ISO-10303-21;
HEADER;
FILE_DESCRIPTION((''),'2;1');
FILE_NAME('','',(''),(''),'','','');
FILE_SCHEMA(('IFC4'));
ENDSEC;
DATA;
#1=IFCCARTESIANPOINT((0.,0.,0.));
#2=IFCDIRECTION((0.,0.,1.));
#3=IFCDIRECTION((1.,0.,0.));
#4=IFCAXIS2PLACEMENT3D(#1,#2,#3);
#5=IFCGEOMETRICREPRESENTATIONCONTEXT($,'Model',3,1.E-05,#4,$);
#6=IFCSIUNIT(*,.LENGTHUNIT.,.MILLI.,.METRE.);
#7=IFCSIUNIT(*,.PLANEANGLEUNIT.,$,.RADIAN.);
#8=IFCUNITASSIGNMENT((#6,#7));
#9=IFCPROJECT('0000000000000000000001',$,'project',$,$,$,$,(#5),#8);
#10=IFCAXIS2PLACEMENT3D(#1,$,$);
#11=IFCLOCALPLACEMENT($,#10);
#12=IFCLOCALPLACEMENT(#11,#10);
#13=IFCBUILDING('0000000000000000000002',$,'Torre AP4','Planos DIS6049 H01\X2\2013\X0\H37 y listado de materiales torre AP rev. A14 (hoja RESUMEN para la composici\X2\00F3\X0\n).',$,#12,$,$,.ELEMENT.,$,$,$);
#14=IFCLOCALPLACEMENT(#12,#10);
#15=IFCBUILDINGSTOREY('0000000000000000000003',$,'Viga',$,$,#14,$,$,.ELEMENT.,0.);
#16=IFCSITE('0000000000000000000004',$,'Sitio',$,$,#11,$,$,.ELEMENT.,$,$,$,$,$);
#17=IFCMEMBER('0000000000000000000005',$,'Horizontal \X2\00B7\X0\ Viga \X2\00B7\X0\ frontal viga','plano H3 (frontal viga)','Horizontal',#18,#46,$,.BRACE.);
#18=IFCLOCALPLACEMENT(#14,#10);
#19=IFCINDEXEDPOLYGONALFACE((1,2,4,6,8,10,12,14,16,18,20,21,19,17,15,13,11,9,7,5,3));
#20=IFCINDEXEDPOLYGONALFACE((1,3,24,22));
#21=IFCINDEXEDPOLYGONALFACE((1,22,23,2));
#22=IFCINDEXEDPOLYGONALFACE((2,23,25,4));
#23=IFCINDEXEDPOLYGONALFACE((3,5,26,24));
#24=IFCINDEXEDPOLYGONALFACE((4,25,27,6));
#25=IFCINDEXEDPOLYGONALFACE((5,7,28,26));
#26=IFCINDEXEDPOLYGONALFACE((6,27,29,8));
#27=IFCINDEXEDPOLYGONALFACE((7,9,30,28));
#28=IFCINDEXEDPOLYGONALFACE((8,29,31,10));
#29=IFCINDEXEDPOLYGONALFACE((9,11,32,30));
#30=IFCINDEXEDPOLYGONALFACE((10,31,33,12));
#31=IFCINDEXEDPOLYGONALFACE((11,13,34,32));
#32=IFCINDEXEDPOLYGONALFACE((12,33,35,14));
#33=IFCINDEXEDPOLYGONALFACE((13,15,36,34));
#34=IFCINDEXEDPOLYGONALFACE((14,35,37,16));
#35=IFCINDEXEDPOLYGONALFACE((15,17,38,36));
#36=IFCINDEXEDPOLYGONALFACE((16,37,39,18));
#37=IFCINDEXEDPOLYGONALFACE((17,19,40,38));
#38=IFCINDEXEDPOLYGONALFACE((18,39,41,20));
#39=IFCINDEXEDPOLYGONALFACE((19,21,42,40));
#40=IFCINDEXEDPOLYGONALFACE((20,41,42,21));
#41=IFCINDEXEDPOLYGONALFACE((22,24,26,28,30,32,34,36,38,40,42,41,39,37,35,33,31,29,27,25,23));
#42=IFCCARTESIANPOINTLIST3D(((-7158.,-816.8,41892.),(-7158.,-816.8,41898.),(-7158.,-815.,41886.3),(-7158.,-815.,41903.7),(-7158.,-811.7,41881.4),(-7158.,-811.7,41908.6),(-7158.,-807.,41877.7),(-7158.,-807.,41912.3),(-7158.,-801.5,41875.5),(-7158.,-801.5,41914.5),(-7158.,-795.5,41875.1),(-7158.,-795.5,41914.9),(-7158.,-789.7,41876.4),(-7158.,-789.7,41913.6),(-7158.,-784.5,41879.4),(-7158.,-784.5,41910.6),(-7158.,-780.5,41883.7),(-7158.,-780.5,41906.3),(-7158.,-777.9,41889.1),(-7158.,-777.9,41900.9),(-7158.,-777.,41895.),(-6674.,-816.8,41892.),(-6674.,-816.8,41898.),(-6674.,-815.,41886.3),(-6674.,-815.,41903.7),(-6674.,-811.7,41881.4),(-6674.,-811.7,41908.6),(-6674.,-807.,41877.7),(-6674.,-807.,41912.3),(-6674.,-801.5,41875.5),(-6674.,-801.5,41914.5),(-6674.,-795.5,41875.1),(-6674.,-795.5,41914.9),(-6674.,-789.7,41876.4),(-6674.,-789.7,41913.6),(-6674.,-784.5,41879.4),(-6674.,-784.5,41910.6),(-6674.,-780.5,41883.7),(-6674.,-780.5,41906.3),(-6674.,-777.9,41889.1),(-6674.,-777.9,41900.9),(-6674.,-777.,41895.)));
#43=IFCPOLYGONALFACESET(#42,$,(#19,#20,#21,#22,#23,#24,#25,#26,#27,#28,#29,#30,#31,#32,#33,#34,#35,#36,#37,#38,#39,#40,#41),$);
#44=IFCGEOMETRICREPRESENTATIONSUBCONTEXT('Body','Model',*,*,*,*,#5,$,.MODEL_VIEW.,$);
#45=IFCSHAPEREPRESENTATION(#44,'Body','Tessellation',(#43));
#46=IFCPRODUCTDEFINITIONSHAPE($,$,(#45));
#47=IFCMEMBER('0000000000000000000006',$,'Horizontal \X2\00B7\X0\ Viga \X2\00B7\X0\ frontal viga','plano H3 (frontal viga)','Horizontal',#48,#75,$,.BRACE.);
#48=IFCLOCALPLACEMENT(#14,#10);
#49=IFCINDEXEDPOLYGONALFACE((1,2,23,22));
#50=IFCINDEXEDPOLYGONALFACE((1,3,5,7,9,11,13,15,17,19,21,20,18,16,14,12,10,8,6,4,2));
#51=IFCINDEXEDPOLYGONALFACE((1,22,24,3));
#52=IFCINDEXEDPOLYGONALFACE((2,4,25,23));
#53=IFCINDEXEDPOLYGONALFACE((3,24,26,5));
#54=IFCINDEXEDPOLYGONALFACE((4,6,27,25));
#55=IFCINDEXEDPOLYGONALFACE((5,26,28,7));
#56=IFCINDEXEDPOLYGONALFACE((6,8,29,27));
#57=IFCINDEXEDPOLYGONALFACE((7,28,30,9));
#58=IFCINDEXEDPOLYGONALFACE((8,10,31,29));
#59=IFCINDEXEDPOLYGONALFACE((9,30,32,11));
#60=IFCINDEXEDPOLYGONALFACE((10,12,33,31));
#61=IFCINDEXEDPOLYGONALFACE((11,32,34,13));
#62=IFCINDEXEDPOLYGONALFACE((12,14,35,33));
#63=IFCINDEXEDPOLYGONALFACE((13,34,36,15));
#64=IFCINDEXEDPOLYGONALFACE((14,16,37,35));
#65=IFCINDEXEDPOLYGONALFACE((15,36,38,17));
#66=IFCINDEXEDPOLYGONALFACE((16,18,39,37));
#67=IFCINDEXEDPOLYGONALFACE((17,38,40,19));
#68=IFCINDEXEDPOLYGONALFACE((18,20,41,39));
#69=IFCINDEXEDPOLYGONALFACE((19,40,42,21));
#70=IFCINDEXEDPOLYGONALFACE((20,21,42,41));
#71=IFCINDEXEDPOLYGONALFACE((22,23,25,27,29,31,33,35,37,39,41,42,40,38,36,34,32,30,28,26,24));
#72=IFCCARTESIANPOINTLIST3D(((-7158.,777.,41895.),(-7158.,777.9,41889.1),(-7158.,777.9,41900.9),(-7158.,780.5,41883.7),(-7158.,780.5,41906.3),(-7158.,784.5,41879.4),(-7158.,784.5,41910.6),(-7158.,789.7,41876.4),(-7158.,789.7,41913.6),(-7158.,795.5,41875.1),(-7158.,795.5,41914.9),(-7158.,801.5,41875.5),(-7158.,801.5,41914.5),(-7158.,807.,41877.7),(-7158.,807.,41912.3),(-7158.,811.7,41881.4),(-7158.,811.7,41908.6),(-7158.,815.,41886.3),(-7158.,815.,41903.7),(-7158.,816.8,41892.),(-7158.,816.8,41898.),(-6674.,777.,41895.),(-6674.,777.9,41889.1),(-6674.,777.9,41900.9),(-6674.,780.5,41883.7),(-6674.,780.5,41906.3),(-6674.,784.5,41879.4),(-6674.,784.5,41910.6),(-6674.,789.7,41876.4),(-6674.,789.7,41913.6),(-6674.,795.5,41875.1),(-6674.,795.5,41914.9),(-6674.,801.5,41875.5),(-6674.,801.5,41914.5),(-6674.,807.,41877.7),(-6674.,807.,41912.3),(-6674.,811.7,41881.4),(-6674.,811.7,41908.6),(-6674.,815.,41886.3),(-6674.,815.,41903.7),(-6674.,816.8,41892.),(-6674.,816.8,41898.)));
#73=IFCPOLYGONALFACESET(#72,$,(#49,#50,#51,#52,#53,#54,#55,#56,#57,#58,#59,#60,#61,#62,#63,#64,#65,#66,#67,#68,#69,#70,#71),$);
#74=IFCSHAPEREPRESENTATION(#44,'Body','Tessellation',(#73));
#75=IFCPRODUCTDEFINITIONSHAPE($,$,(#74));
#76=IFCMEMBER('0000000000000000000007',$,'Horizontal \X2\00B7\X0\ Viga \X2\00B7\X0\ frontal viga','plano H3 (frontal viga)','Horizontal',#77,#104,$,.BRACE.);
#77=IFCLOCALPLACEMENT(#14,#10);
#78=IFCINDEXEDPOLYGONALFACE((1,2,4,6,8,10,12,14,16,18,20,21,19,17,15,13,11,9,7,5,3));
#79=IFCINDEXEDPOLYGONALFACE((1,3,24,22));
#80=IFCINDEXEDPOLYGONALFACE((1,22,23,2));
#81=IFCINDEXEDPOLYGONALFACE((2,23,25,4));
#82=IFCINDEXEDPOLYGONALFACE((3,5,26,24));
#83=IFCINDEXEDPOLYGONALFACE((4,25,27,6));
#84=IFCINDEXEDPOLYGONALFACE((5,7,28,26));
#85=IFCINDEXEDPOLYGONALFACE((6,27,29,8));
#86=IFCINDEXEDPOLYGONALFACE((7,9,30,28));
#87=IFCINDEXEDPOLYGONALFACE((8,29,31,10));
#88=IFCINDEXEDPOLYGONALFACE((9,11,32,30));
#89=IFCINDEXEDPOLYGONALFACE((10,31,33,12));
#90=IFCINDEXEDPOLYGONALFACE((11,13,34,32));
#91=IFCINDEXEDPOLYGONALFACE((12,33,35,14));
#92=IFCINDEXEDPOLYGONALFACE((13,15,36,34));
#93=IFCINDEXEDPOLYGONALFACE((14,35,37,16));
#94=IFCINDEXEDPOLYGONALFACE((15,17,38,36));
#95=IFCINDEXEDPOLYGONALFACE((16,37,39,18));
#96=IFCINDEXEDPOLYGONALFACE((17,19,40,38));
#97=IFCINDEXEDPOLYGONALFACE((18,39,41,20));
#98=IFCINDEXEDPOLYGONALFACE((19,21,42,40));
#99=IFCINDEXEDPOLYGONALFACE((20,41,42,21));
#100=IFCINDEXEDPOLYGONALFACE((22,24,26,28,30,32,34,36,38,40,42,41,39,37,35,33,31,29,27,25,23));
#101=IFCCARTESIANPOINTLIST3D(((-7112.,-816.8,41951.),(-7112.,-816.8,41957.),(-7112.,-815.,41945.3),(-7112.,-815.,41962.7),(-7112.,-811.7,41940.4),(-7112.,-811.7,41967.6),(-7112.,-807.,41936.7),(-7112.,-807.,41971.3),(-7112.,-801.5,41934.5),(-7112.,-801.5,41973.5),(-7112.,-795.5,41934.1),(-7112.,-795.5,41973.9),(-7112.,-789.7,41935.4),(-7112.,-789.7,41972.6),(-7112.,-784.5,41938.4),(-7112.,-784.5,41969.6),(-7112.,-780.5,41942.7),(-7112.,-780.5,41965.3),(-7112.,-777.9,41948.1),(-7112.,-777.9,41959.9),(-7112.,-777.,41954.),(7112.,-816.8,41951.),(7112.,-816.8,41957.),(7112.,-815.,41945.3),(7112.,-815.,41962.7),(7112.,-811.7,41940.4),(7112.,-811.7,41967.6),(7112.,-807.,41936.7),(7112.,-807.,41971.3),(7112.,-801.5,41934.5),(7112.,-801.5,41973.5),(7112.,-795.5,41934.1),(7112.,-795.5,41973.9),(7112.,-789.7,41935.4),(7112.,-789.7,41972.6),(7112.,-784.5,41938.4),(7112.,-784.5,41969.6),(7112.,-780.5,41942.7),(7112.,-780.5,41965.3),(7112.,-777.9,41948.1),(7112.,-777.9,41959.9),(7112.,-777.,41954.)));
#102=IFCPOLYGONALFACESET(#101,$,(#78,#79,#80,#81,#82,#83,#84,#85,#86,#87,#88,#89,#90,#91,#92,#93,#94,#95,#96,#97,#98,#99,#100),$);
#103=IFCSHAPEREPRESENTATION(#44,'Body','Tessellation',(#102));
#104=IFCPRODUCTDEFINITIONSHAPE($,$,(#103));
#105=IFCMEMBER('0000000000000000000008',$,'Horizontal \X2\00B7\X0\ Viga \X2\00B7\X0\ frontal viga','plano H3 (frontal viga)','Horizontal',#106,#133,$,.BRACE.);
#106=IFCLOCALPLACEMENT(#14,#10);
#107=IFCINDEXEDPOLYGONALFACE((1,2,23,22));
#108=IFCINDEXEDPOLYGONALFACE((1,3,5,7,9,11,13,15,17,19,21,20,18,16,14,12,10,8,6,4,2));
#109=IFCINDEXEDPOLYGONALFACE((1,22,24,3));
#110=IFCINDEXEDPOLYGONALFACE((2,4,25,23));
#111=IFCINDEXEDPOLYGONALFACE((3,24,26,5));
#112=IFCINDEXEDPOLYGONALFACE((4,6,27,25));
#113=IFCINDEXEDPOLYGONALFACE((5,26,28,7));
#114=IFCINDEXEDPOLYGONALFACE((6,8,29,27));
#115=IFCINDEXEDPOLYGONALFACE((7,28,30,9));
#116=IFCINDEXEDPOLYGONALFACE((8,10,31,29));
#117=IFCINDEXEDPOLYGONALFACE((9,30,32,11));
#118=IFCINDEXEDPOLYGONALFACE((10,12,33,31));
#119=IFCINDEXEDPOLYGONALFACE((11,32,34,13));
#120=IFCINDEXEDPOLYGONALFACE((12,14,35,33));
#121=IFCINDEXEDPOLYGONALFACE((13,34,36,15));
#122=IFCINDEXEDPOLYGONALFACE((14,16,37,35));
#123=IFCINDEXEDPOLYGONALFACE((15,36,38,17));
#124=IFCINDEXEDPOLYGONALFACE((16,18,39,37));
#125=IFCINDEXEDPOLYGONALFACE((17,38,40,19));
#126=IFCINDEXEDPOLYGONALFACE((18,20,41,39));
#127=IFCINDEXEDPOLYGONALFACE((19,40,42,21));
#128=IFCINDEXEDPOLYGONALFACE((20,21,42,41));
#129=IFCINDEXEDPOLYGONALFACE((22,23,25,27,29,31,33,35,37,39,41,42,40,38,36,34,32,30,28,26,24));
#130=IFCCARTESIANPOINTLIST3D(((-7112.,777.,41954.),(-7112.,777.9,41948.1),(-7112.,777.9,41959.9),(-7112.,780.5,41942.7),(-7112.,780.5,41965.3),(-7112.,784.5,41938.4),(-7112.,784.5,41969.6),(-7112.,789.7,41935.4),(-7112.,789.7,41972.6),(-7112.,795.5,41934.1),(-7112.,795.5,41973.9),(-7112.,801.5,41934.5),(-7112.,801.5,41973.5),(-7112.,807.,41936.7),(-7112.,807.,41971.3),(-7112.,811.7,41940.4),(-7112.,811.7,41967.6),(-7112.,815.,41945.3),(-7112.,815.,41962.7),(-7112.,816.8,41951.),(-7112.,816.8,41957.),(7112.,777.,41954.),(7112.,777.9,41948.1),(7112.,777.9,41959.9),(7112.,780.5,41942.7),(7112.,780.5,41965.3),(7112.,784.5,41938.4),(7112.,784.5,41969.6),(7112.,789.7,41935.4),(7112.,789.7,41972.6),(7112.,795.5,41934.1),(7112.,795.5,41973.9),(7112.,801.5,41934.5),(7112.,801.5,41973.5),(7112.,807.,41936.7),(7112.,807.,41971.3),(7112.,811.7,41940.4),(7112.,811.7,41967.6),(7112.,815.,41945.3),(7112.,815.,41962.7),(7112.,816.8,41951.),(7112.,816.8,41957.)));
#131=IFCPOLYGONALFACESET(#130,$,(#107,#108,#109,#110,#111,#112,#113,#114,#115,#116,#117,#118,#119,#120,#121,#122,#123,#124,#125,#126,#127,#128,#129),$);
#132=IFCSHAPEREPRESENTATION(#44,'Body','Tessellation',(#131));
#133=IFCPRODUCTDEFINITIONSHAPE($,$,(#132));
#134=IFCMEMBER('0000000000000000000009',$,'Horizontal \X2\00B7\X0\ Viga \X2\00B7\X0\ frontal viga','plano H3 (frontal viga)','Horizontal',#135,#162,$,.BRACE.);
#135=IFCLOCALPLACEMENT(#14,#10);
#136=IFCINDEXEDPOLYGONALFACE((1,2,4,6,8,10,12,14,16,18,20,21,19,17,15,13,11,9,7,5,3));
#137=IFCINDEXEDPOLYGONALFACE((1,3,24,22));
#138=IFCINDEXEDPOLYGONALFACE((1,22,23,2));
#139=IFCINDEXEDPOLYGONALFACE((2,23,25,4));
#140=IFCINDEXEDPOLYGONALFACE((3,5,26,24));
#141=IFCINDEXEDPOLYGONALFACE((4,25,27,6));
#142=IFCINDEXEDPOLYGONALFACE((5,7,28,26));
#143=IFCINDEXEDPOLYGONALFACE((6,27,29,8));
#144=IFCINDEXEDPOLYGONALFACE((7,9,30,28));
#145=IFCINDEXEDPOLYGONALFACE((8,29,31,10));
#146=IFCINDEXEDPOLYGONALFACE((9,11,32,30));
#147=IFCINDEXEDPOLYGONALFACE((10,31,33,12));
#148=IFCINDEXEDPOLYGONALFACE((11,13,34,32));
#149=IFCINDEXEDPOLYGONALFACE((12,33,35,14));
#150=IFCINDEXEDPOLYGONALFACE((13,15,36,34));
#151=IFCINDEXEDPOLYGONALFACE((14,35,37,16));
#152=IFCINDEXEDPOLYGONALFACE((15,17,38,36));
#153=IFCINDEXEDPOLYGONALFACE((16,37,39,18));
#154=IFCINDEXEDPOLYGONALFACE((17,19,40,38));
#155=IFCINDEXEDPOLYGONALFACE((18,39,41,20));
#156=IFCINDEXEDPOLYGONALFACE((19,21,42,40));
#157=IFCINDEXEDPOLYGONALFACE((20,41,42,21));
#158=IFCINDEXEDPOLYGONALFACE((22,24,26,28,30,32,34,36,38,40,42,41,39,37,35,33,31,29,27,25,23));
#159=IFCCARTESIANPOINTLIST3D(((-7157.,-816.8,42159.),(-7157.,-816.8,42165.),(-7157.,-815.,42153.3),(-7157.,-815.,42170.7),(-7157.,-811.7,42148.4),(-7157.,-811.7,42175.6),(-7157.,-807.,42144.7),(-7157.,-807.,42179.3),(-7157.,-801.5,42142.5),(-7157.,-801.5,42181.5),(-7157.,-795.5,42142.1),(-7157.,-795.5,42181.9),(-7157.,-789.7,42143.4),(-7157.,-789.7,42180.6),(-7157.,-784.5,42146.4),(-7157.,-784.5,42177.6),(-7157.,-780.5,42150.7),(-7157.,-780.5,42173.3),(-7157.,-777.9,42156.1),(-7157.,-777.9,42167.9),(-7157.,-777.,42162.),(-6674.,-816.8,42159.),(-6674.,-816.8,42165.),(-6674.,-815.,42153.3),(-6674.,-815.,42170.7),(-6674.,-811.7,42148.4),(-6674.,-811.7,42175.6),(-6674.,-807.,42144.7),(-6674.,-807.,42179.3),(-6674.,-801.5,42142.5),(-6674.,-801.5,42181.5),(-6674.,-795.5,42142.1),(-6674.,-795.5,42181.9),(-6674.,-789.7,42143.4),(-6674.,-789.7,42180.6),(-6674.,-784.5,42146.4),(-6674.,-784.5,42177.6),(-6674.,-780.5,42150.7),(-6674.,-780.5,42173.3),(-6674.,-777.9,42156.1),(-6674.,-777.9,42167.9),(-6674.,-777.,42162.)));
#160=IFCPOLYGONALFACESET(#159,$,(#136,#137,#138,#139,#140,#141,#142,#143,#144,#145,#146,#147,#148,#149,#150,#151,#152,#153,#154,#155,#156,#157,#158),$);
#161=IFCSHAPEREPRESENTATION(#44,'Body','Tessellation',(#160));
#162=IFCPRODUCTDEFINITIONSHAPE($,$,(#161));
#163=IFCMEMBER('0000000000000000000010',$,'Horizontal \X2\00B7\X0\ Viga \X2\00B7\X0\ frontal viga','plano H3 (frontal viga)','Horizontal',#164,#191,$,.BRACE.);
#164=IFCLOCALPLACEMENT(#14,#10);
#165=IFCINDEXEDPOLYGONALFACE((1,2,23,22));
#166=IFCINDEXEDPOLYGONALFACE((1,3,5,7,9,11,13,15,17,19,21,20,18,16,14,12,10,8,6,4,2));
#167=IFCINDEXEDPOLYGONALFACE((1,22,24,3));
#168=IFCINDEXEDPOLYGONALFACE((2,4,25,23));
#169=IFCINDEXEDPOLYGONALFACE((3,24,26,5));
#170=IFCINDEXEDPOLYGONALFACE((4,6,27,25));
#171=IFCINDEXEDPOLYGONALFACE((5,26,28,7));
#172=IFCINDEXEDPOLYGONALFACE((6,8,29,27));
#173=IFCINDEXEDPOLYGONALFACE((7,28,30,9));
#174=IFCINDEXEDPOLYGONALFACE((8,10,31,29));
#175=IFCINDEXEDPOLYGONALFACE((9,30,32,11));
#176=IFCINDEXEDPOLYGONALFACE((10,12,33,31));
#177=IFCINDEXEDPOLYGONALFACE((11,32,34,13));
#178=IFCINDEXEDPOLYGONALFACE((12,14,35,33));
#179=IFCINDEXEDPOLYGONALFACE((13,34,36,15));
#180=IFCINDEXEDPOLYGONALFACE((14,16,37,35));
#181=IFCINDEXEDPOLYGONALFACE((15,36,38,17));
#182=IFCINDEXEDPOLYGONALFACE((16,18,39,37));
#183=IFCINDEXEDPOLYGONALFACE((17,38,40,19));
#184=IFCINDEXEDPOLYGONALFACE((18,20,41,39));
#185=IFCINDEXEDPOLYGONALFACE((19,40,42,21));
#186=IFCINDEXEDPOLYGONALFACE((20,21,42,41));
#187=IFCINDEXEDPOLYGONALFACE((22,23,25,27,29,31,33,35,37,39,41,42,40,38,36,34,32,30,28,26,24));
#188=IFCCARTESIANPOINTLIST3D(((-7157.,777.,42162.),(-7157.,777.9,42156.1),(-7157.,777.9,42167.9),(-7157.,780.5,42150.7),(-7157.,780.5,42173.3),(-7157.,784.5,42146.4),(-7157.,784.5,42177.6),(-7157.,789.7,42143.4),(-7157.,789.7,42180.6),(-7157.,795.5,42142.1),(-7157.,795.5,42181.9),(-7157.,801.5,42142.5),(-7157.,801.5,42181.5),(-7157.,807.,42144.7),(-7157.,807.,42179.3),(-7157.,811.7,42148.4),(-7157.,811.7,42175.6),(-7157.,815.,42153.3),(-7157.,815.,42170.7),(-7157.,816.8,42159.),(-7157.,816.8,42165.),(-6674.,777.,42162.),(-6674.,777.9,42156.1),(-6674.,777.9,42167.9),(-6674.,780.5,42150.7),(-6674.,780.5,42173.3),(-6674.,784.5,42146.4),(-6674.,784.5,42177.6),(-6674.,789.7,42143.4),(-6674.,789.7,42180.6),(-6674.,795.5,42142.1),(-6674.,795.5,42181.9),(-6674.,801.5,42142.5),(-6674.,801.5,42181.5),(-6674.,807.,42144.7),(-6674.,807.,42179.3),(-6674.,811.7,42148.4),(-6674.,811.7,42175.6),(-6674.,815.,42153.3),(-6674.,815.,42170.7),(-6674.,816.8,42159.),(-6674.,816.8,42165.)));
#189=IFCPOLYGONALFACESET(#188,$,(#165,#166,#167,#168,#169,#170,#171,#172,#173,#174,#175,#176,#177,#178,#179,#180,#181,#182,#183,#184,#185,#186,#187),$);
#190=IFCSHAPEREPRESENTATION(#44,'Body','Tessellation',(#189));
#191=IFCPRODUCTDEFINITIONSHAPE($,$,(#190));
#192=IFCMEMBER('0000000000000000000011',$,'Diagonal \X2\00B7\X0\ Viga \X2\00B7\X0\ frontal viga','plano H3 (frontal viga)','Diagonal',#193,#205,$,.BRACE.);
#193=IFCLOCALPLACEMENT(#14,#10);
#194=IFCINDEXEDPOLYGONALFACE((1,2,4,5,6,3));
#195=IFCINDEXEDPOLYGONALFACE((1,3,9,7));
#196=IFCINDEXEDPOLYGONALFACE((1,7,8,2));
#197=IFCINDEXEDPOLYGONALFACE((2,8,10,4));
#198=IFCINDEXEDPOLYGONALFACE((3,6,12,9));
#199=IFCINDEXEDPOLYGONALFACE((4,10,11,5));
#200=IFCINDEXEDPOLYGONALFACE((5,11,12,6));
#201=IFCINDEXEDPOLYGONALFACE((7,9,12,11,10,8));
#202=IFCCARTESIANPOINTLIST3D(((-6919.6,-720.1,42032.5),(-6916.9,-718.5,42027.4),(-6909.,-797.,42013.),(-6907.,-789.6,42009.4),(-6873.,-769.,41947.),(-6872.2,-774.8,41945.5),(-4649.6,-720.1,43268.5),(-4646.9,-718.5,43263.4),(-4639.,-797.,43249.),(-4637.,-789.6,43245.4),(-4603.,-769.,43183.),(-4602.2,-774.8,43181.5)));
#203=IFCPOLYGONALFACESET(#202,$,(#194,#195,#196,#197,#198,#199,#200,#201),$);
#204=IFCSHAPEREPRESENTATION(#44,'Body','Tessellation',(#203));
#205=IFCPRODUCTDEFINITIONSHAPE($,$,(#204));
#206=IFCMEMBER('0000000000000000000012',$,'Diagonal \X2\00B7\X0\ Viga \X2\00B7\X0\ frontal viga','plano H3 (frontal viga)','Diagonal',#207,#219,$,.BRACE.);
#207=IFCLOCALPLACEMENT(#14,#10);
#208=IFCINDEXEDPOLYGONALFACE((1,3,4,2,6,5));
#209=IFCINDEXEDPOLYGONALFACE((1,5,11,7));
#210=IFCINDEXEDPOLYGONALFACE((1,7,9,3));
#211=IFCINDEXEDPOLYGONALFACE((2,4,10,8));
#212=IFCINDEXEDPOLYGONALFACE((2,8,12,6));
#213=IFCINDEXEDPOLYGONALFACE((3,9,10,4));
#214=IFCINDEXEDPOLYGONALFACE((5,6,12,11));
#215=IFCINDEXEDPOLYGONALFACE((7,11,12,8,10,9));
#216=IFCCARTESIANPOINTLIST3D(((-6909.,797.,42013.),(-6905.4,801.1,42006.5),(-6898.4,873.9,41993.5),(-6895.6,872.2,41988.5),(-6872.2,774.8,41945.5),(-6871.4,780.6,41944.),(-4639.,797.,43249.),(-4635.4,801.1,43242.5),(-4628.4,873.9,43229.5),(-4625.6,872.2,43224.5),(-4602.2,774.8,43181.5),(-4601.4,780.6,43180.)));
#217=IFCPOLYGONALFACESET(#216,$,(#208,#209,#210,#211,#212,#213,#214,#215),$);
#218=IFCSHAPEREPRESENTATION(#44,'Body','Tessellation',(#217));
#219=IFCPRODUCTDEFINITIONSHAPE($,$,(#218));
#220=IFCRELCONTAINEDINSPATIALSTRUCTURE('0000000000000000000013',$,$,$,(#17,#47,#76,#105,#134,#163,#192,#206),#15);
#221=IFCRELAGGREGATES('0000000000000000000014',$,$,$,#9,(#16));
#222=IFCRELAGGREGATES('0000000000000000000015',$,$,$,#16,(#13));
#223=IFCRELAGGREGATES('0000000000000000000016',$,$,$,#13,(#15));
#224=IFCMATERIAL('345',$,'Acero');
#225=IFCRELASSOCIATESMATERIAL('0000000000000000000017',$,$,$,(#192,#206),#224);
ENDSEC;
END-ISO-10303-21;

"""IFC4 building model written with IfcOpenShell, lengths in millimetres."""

from ifc_helpers import new_model, si_unit, frame, frame_2d, origin, origin_with_axes, place, context, subcontext, project, spatial, circle, l_section, extrude, material, element, save


model = new_model("IFC4")

# Units and contexts
model_context = context("Model", 3, precision=1e-05, world=origin_with_axes())
body_context = subcontext(model_context, "Body", "Model", "MODEL_VIEW")
ifc_project = project(units=[si_unit("LENGTHUNIT", "METRE", prefix="MILLI"), si_unit("PLANEANGLEUNIT", "RADIAN")], contexts=[model_context])

# Site, building, storey
site_placement = place(None, origin())
site = spatial("IfcSite", under=ifc_project, at=site_placement, Name="Sitio", CompositionType="ELEMENT")
building_placement = place(site_placement, origin())
building = spatial("IfcBuilding", under=site, at=building_placement, Name="Torre AP4", Description="Planos DIS6049 H01–H37 y listado de materiales torre AP rev. A14 (hoja RESUMEN para la composición).", CompositionType="ELEMENT")
storey_placement = place(building_placement, origin())
storey = spatial("IfcBuildingStorey", under=building, at=storey_placement, Name="Viga", CompositionType="ELEMENT", Elevation=0.0)

# Members
for number, where, z_axis, x_axis, name in (
    (1, (-7158.0, -797.0, 41895.0), (1.0, 0.0, 0.0), (0.0, 1.0, 0.0), "Horizontal · Viga · frontal viga"),
    (2, (-7158.0, 797.0, 41895.0), (1.0, 0.0, 0.0), (0.0, -1.0, 0.0), "Horizontal · Viga · frontal viga"),
):
    element("IfcMember", number, at=place(storey_placement, frame(where, z_axis=z_axis, x_axis=x_axis)), inside=storey, Name=name, Description="plano H3 (frontal viga)", ObjectType="Horizontal", PredefinedType="BRACE", context=body_context, shape_type="SweptSolid", body=[
        extrude(circle(Radius=20.0), None, (0.0, 0.0, 1.0), 484.0),
    ])
for number, where, z_axis, x_axis, name in (
    (3, (-7112.0, -797.0, 41954.0), (1.0, 0.0, 0.0), (0.0, 1.0, 0.0), "Horizontal · Viga · frontal viga"),
    (4, (-7112.0, 797.0, 41954.0), (1.0, 0.0, 0.0), (0.0, -1.0, 0.0), "Horizontal · Viga · frontal viga"),
):
    element("IfcMember", number, at=place(storey_placement, frame(where, z_axis=z_axis, x_axis=x_axis)), inside=storey, Name=name, Description="plano H3 (frontal viga)", ObjectType="Horizontal", PredefinedType="BRACE", context=body_context, shape_type="SweptSolid", body=[
        extrude(circle(Radius=20.0), None, (0.0, 0.0, 1.0), 14224.0),
    ])
for number, where, z_axis, x_axis, name in (
    (5, (-7157.0, -797.0, 42162.0), (1.0, 0.0, 0.0), (0.0, 1.0, 0.0), "Horizontal · Viga · frontal viga"),
    (6, (-7157.0, 797.0, 42162.0), (1.0, 0.0, 0.0), (0.0, -1.0, 0.0), "Horizontal · Viga · frontal viga"),
):
    element("IfcMember", number, at=place(storey_placement, frame(where, z_axis=z_axis, x_axis=x_axis)), inside=storey, Name=name, Description="plano H3 (frontal viga)", ObjectType="Horizontal", PredefinedType="BRACE", context=body_context, shape_type="SweptSolid", body=[
        extrude(circle(Radius=20.0), None, (0.0, 0.0, 1.0), 483.0),
    ])
ifc_material_1 = material(Name="345", Category="Acero")
for number, where, z_axis, x_axis, name in (
    (7, (-6909.0, -797.0, 42013.0), (0.87825, 0.0, 0.478201), (0.459444, 0.277327, -0.843801), "Diagonal · Viga · frontal viga"),
    (8, (-6909.0, 797.0, 42013.0), (0.87825, 0.0, 0.478201), (0.459444, -0.277327, -0.843801), "Diagonal · Viga · frontal viga"),
):
    element("IfcMember", number, at=place(storey_placement, frame(where, z_axis=z_axis, x_axis=x_axis)), inside=storey, material=ifc_material_1, Name=name, Description="plano H3 (frontal viga)", ObjectType="Diagonal", PredefinedType="BRACE", context=body_context, shape_type="SweptSolid", body=[
        extrude(l_section(Depth=80.0, Width=80.0, Thickness=6.0, at=frame_2d((40.0, 40.0))), None, (0.0, 0.0, 1.0), 2584.7),
    ])

save(model, "model.ifc")
